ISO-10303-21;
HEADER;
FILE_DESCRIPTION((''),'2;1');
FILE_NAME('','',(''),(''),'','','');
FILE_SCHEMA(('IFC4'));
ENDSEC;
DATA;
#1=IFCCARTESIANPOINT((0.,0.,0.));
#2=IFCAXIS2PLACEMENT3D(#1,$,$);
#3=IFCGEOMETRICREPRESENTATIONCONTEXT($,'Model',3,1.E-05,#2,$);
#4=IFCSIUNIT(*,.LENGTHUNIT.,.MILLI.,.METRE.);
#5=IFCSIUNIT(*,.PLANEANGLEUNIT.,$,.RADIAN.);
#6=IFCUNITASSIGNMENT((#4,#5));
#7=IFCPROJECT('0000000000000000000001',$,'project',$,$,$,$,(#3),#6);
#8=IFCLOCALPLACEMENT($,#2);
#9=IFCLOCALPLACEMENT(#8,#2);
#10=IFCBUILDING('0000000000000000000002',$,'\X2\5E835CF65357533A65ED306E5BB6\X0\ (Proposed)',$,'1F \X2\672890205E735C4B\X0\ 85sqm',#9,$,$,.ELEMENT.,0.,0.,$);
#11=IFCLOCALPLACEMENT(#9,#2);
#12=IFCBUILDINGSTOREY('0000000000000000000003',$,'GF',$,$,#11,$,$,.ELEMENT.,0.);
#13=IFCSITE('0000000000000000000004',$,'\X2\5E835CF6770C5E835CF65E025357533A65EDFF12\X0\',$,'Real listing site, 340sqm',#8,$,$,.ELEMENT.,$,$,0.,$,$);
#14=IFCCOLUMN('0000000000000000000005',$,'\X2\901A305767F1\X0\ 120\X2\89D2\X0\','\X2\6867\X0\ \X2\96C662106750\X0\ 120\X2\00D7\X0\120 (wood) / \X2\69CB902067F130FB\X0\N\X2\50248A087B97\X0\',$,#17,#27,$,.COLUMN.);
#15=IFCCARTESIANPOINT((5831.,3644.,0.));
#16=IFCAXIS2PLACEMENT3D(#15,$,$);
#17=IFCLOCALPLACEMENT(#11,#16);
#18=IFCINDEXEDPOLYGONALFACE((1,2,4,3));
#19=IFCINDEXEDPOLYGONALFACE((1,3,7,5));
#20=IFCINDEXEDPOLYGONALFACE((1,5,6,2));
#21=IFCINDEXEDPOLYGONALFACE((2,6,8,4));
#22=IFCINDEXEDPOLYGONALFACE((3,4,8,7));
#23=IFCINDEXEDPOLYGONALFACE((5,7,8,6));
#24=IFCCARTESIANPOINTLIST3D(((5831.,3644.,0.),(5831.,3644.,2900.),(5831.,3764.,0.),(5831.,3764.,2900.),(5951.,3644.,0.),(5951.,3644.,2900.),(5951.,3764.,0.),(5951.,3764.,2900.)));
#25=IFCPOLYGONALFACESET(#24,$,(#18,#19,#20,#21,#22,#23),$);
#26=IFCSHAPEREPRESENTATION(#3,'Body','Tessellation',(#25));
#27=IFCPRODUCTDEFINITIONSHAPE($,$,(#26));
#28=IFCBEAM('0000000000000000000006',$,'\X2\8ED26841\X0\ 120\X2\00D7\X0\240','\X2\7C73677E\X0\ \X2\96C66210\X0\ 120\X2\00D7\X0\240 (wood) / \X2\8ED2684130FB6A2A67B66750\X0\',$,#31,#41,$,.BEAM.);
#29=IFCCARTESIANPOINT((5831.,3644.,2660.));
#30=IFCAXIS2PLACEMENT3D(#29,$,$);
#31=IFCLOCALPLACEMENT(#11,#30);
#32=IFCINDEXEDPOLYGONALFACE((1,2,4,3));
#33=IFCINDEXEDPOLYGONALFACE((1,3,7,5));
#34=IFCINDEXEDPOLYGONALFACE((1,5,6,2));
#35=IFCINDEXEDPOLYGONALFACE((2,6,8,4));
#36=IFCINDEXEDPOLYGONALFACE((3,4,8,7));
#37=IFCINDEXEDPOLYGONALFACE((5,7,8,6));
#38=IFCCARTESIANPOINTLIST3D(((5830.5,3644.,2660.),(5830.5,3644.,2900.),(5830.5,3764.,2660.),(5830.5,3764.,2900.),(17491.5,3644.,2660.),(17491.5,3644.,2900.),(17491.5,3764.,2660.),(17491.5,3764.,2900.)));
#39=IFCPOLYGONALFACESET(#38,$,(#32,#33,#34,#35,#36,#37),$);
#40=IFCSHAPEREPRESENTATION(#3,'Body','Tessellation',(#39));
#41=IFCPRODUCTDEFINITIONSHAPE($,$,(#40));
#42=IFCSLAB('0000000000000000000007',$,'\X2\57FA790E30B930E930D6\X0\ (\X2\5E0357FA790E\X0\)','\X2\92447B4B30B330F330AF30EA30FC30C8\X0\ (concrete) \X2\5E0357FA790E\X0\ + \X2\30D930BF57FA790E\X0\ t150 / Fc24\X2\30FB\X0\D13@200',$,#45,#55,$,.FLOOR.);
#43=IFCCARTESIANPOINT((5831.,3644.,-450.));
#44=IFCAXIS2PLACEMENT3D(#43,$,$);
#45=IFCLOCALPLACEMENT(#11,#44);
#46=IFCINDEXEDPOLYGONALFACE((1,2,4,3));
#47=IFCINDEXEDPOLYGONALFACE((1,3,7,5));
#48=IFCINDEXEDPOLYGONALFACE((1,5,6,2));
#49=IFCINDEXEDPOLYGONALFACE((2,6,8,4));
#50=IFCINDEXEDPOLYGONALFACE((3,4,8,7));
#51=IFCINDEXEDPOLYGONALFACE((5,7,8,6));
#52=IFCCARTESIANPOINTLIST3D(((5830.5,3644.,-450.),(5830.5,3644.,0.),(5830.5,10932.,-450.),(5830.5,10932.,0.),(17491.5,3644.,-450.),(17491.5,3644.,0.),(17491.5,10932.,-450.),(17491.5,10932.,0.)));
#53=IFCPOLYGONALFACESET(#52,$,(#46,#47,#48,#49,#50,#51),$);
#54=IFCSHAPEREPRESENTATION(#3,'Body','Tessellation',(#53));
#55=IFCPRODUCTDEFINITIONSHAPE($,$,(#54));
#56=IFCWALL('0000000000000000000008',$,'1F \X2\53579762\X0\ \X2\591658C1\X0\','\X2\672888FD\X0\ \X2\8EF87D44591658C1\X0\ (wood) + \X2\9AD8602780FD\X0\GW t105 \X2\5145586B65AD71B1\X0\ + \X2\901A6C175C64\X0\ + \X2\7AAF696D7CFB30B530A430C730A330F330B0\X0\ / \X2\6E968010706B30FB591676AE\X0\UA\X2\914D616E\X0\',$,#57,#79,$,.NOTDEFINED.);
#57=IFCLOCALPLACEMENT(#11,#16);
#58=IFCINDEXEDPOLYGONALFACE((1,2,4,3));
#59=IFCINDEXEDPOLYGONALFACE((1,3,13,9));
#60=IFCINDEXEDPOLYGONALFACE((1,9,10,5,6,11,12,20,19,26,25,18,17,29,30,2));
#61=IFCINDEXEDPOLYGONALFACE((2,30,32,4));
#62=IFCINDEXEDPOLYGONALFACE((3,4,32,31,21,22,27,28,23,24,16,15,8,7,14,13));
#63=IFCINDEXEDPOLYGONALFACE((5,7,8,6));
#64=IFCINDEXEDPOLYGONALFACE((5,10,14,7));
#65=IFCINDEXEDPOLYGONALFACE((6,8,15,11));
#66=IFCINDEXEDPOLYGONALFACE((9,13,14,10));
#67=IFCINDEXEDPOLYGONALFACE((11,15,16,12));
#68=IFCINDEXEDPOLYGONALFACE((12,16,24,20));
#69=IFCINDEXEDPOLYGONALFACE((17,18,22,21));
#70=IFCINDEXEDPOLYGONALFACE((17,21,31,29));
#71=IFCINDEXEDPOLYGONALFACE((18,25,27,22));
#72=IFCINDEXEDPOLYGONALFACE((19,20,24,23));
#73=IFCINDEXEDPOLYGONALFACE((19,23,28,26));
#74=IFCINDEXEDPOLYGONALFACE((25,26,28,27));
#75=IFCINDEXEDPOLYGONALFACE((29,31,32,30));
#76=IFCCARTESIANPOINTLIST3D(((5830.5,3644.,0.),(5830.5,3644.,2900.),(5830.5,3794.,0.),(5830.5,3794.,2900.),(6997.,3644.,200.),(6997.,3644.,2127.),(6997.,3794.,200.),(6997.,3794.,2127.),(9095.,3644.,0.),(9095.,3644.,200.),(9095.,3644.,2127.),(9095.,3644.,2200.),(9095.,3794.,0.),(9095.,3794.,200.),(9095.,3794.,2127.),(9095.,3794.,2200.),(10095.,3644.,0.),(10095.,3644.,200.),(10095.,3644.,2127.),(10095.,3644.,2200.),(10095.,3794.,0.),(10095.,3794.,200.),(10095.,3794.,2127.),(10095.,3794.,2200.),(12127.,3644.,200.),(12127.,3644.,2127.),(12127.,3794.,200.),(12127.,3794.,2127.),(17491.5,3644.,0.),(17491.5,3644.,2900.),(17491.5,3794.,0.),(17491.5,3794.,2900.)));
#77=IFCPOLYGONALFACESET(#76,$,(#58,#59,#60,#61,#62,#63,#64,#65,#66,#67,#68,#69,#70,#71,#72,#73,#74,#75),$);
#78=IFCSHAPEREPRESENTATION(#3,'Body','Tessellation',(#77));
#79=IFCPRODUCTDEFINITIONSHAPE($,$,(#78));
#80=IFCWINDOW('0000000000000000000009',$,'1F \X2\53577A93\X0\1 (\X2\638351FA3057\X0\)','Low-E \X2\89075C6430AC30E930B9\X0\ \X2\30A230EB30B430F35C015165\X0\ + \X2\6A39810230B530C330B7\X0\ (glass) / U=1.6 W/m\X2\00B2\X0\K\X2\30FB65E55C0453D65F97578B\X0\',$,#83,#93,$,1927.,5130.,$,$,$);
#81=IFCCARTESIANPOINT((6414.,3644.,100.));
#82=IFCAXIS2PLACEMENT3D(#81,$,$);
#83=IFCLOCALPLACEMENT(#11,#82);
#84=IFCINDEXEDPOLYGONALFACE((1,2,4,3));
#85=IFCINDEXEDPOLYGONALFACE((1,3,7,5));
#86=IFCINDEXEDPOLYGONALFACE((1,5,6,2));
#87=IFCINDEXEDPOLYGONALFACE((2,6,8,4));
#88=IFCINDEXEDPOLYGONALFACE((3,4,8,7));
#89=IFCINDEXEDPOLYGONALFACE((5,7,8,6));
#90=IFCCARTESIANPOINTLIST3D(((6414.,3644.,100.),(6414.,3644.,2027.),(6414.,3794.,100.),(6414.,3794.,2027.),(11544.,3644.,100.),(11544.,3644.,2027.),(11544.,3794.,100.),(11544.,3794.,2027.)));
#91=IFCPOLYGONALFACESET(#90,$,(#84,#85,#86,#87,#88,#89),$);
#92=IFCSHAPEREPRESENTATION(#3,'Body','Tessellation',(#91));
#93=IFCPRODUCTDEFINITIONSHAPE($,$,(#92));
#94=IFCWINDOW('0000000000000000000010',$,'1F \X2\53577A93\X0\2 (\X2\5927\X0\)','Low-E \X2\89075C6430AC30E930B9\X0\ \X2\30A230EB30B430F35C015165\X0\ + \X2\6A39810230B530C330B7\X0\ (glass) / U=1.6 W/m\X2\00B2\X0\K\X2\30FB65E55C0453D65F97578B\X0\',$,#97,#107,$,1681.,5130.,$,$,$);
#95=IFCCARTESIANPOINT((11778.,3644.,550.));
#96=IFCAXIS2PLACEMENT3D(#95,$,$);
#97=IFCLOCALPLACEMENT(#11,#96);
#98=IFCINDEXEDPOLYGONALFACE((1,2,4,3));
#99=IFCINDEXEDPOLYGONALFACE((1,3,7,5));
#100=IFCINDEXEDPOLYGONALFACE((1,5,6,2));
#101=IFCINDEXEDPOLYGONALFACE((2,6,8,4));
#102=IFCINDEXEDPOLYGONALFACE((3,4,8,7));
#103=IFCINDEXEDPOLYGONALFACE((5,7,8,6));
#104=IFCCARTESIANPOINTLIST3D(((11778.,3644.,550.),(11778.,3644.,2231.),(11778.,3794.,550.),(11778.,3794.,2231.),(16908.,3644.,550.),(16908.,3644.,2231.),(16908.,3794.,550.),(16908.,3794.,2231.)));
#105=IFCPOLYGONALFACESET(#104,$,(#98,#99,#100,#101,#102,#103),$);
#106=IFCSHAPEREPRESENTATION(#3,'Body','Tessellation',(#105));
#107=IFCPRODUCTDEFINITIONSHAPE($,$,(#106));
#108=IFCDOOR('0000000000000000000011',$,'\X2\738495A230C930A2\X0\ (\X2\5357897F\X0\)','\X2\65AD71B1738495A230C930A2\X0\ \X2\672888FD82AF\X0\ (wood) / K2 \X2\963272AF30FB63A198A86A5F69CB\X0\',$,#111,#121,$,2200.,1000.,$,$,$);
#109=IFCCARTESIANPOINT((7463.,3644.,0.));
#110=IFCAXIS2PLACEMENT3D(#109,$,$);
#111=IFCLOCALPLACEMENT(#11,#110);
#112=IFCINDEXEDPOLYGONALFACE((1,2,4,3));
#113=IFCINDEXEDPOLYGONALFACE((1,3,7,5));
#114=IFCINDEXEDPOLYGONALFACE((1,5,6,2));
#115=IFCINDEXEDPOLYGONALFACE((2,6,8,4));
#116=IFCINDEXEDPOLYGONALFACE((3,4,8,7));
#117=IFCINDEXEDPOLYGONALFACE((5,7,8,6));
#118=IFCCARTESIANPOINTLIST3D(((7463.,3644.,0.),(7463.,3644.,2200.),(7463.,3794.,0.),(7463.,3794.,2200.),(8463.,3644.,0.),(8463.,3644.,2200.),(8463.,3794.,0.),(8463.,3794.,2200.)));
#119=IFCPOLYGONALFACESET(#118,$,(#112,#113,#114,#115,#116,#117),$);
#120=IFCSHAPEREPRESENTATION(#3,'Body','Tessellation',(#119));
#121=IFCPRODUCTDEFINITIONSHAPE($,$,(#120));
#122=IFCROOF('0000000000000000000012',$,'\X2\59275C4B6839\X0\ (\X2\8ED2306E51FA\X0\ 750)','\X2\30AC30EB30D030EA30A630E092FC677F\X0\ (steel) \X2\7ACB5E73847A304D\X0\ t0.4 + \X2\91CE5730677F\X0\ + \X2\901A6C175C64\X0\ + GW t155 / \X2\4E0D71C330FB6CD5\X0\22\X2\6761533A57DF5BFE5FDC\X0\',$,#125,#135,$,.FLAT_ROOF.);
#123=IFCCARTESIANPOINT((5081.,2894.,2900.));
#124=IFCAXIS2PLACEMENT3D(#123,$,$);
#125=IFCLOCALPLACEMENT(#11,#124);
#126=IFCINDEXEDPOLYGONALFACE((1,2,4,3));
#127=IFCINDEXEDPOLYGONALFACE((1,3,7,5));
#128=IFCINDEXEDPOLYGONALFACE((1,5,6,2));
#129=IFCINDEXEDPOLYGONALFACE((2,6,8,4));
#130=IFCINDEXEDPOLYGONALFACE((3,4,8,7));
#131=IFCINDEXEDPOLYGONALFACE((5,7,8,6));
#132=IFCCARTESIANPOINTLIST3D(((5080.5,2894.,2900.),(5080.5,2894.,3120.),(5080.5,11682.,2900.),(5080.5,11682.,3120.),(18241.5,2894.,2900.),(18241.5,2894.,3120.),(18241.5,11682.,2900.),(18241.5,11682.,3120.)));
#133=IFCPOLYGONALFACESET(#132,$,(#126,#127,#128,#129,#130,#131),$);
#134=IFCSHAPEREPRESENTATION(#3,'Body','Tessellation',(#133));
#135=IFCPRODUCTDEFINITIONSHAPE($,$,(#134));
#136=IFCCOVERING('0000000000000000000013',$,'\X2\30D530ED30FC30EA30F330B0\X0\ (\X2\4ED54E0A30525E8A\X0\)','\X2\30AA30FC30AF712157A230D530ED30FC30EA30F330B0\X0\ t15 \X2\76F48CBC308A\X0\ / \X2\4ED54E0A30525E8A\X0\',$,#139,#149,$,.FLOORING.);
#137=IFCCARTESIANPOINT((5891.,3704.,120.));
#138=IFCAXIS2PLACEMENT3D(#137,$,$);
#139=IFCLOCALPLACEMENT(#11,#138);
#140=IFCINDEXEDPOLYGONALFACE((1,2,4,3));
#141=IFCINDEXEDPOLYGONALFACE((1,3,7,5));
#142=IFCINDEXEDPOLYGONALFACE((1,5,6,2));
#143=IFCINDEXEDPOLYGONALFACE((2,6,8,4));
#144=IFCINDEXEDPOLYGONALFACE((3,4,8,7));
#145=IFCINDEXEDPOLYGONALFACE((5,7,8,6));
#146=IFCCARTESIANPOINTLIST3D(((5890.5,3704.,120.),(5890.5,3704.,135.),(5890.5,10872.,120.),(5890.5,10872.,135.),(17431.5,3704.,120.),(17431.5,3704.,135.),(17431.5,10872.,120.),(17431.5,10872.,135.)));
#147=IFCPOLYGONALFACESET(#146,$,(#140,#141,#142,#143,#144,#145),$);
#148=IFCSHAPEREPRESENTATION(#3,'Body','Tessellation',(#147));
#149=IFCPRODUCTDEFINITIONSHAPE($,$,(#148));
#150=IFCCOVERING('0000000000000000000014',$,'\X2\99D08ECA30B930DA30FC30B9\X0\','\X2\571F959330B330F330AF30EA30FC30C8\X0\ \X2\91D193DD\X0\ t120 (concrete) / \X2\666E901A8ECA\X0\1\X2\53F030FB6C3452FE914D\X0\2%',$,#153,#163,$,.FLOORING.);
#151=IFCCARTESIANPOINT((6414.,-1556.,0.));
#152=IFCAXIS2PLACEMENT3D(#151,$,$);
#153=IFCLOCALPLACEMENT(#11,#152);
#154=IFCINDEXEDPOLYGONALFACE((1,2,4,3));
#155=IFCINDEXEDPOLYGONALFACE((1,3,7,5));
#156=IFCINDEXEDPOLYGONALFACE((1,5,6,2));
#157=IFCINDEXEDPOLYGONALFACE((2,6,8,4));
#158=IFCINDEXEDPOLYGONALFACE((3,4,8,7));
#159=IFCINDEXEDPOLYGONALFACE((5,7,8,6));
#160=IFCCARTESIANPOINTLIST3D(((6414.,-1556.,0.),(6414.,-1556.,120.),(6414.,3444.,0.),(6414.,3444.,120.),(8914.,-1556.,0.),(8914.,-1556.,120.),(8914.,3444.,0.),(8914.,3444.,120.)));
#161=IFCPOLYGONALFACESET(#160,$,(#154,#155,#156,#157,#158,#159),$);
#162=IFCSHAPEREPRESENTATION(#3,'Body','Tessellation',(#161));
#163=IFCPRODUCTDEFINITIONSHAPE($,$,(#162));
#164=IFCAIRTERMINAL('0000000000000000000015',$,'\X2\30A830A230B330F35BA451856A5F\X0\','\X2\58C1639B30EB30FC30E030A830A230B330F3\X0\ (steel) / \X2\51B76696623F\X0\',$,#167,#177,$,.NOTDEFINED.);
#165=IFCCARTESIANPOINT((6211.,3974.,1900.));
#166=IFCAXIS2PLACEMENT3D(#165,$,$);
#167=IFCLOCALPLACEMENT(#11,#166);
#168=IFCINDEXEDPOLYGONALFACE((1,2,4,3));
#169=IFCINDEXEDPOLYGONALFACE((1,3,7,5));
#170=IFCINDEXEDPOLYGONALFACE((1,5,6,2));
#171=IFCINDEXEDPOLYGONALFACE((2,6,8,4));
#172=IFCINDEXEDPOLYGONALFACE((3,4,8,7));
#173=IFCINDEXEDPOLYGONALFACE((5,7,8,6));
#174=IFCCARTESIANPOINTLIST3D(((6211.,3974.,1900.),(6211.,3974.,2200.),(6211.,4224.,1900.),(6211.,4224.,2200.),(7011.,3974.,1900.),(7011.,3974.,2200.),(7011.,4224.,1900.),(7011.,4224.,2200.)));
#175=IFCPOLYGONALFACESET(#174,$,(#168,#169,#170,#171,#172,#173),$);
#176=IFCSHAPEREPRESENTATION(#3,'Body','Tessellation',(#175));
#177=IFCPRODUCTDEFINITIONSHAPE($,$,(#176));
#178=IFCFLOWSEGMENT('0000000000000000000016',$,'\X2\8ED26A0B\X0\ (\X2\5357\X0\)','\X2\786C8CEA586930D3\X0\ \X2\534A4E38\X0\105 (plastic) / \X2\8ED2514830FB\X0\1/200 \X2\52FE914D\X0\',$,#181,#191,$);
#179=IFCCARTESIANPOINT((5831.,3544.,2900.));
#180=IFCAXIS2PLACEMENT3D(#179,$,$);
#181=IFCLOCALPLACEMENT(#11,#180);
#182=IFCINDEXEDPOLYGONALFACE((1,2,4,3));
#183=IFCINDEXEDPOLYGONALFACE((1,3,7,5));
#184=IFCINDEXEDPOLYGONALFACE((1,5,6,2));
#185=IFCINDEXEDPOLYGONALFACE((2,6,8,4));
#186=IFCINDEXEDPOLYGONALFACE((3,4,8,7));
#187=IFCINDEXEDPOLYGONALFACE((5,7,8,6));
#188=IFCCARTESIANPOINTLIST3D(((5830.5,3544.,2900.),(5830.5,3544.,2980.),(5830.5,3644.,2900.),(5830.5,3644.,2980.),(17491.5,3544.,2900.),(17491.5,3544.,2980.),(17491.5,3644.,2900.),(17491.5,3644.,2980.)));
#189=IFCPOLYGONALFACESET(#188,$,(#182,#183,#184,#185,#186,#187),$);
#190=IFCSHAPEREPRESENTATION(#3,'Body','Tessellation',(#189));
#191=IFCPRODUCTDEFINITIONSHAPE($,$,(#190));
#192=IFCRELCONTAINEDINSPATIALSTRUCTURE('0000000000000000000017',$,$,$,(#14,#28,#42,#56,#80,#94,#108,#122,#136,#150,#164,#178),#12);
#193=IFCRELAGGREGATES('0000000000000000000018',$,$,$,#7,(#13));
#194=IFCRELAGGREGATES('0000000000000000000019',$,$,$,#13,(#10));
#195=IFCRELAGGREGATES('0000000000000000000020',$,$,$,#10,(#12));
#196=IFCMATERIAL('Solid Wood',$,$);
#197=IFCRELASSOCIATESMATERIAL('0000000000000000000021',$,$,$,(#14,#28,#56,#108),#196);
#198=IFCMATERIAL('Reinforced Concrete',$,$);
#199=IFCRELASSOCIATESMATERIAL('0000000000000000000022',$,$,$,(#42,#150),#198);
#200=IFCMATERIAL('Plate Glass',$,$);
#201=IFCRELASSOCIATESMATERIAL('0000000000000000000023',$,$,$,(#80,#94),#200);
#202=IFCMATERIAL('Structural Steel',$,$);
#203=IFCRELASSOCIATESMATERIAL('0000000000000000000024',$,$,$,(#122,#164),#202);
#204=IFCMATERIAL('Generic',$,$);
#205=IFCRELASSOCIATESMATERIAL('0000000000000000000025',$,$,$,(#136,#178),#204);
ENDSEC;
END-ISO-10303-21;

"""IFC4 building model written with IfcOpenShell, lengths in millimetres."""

from ifc_helpers import new_model, si_unit, frame, frame_2d, origin, place, context, project, spatial, rectangle, extrude, material, element, fill, save


model = new_model("IFC4")

# Units and contexts
model_context = context("Model", 3, precision=1e-05, world=origin())
ifc_project = project(units=[si_unit("LENGTHUNIT", "METRE", prefix="MILLI"), si_unit("PLANEANGLEUNIT", "RADIAN")], contexts=[model_context])

# Site, building, storey
site_placement = place(None, origin())
site = spatial("IfcSite", under=ifc_project, at=site_placement, Name="広島県広島市南区旭２", ObjectType="Real listing site, 340sqm", CompositionType="ELEMENT", RefElevation=0.0)
building_placement = place(site_placement, origin())
building = spatial("IfcBuilding", under=site, at=building_placement, Name="広島南区旭の家 (Proposed)", ObjectType="1F 木造平屋 85sqm", CompositionType="ELEMENT", ElevationOfRefHeight=0.0, ElevationOfTerrain=0.0)
storey_placement = place(building_placement, origin())
storey = spatial("IfcBuildingStorey", under=building, at=storey_placement, Name="GF", CompositionType="ELEMENT", Elevation=0.0)

# Column
ifc_material_1 = material(Name="Solid Wood")
column_1_placement = place(storey_placement, frame((5831.0, 3644.0, 0.0)))
element("IfcColumn", 1, at=column_1_placement, inside=storey, material=ifc_material_1, Name="通し柱 120角", Description="桧 集成材 120×120 (wood) / 構造柱・N値計算", PredefinedType="COLUMN", context=model_context, shape_type="SweptSolid", body=[
    extrude(rectangle(XDim=120.0, YDim=120.0, at=frame_2d((60.0, 60.0))), frame((5831.0, 3644.0, 0.0)), (0.0, 0.0, 1.0), 2900.0),
])

# Beam
beam_1_placement = place(storey_placement, frame((5831.0, 3644.0, 2660.0)))
element("IfcBeam", 2, at=beam_1_placement, inside=storey, material=ifc_material_1, Name="軒桁 120×240", Description="米松 集成 120×240 (wood) / 軒桁・横架材", PredefinedType="BEAM", context=model_context, shape_type="SweptSolid", body=[
    extrude(rectangle(XDim=11661.0, YDim=120.0, at=frame_2d((5830.0, 60.0))), frame((5831.0, 3644.0, 2660.0)), (0.0, 0.0, 1.0), 240.0),
])

# Slab
ifc_material_2 = material(Name="Reinforced Concrete")
slab_1_placement = place(storey_placement, frame((5831.0, 3644.0, -450.0)))
element("IfcSlab", 3, at=slab_1_placement, inside=storey, material=ifc_material_2, Name="基礎スラブ (布基礎)", Description="鉄筋コンクリート (concrete) 布基礎 + ベタ基礎 t150 / Fc24・D13@200", PredefinedType="FLOOR", context=model_context, shape_type="SweptSolid", body=[
    extrude(rectangle(XDim=11661.0, YDim=7288.0, at=frame_2d((5830.0, 3644.0))), frame((5831.0, 3644.0, -450.0)), (0.0, 0.0, 1.0), 450.0),
])

# Wall, openings, windows, door
wall_1_placement = place(storey_placement, frame((5831.0, 3644.0, 0.0)))
wall_1 = element("IfcWall", 4, at=wall_1_placement, inside=storey, material=ifc_material_1, Name="1F 南面 外壁", Description="木製 軸組外壁 (wood) + 高性能GW t105 充填断熱 + 通気層 + 窯業系サイディング / 準耐火・外皮UA配慮", PredefinedType="NOTDEFINED", context=model_context, shape_type="SweptSolid", body=[
    extrude(rectangle(XDim=11661.0, YDim=150.0, at=frame_2d((5830.0, 75.0))), frame((5831.0, 3644.0, 0.0)), (0.0, 0.0, 1.0), 2900.0),
])
opening_1_placement = place(storey_placement, frame((6414.0, 3644.0, 100.0)))
opening_1 = element("IfcOpeningElement", 5, at=opening_1_placement, cuts=wall_1, PredefinedType="NOTDEFINED", context=model_context, shape_type="SweptSolid", body=[
    extrude(rectangle(XDim=5130.0, YDim=150.0, at=frame_2d((2565.0, 75.0))), frame((6414.0, 3644.0, 100.0)), (0.0, 0.0, 1.0), 1927.0),
])
opening_2_placement = place(storey_placement, frame((11778.0, 3644.0, 550.0)))
opening_2 = element("IfcOpeningElement", 6, at=opening_2_placement, cuts=wall_1, PredefinedType="NOTDEFINED", context=model_context, shape_type="SweptSolid", body=[
    extrude(rectangle(XDim=5130.0, YDim=150.0, at=frame_2d((2565.0, 75.0))), frame((11778.0, 3644.0, 550.0)), (0.0, 0.0, 1.0), 1681.0),
])
opening_3_placement = place(storey_placement, frame((7463.0, 3644.0, 0.0)))
opening_3 = element("IfcOpeningElement", 7, at=opening_3_placement, cuts=wall_1, PredefinedType="NOTDEFINED", context=model_context, shape_type="SweptSolid", body=[
    extrude(rectangle(XDim=1000.0, YDim=150.0, at=frame_2d((500.0, 75.0))), frame((7463.0, 3644.0, 0.0)), (0.0, 0.0, 1.0), 2200.0),
])
ifc_material_3 = material(Name="Plate Glass")
window_1_placement = place(storey_placement, frame((6414.0, 3644.0, 100.0)))
window_1 = element("IfcWindow", 8, at=window_1_placement, inside=storey, material=ifc_material_3, Name="1F 南窓1 (掃出し)", Description="Low-E 複層ガラス アルゴン封入 + 樹脂サッシ (glass) / U=1.6 W/m²K・日射取得型", OverallHeight=1927.0, OverallWidth=5130.0, context=model_context, shape_type="SweptSolid", body=[
    extrude(rectangle(XDim=5130.0, YDim=150.0, at=frame_2d((2565.0, 75.0))), frame((6414.0, 3644.0, 100.0)), (0.0, 0.0, 1.0), 1927.0),
])
fill(opening_1, window_1)
window_2_placement = place(storey_placement, frame((11778.0, 3644.0, 550.0)))
window_2 = element("IfcWindow", 9, at=window_2_placement, inside=storey, material=ifc_material_3, Name="1F 南窓2 (大)", Description="Low-E 複層ガラス アルゴン封入 + 樹脂サッシ (glass) / U=1.6 W/m²K・日射取得型", OverallHeight=1681.0, OverallWidth=5130.0, context=model_context, shape_type="SweptSolid", body=[
    extrude(rectangle(XDim=5130.0, YDim=150.0, at=frame_2d((2565.0, 75.0))), frame((11778.0, 3644.0, 550.0)), (0.0, 0.0, 1.0), 1681.0),
])
fill(opening_2, window_2)
door_placement = place(storey_placement, frame((7463.0, 3644.0, 0.0)))
door = element("IfcDoor", 10, at=door_placement, inside=storey, material=ifc_material_1, Name="玄関ドア (南西)", Description="断熱玄関ドア 木製芯 (wood) / K2 防犯・採風機構", OverallHeight=2200.0, OverallWidth=1000.0, context=model_context, shape_type="SweptSolid", body=[
    extrude(rectangle(XDim=1000.0, YDim=150.0, at=frame_2d((500.0, 75.0))), frame((7463.0, 3644.0, 0.0)), (0.0, 0.0, 1.0), 2200.0),
])
fill(opening_3, door)

# Roof
ifc_material_4 = material(Name="Structural Steel")
roof_placement = place(storey_placement, frame((5081.0, 2894.0, 2900.0)))
element("IfcRoof", 11, at=roof_placement, inside=storey, material=ifc_material_4, Name="大屋根 (軒の出 750)", Description="ガルバリウム鋼板 (steel) 立平葺き t0.4 + 野地板 + 通気層 + GW t155 / 不燃・法22条区域対応", PredefinedType="FLAT_ROOF", context=model_context, shape_type="SweptSolid", body=[
    extrude(rectangle(XDim=13161.0, YDim=8788.0, at=frame_2d((6580.0, 4394.0))), frame((5081.0, 2894.0, 2900.0)), (0.0, 0.0, 1.0), 220.0),
])

# Coverings
ifc_material_5 = material(Name="Generic")
covering_1_placement = place(storey_placement, frame((5891.0, 3704.0, 120.0)))
element("IfcCovering", 12, at=covering_1_placement, inside=storey, material=ifc_material_5, Name="フローリング (仕上げ床)", Description="オーク無垢フローリング t15 直貼り / 仕上げ床", PredefinedType="FLOORING", context=model_context, shape_type="SweptSolid", body=[
    extrude(rectangle(XDim=11541.0, YDim=7168.0, at=frame_2d((5770.0, 3584.0))), frame((5891.0, 3704.0, 120.0)), (0.0, 0.0, 1.0), 15.0),
])
covering_2_placement = place(storey_placement, frame((6414.0, -1556.0, 0.0)))
element("IfcCovering", 13, at=covering_2_placement, inside=storey, material=ifc_material_2, Name="駐車スペース", Description="土間コンクリート 金鏝 t120 (concrete) / 普通車1台・水勾配2%", PredefinedType="FLOORING", context=model_context, shape_type="SweptSolid", body=[
    extrude(rectangle(XDim=2500.0, YDim=5000.0, at=frame_2d((1250.0, 2500.0))), frame((6414.0, -1556.0, 0.0)), (0.0, 0.0, 1.0), 120.0),
])

# Air terminal
air_terminal_placement = place(storey_placement, frame((6211.0, 3974.0, 1900.0)))
element("IfcAirTerminal", 14, at=air_terminal_placement, inside=storey, material=ifc_material_4, Name="エアコン室内機", Description="壁掛ルームエアコン (steel) / 冷暖房", PredefinedType="NOTDEFINED", context=model_context, shape_type="SweptSolid", body=[
    extrude(rectangle(XDim=800.0, YDim=250.0, at=frame_2d((400.0, 125.0))), frame((6211.0, 3974.0, 1900.0)), (0.0, 0.0, 1.0), 300.0),
])

# Flow segment
flow_segment_1_placement = place(storey_placement, frame((5831.0, 3544.0, 2900.0)))
element("IfcFlowSegment", 15, at=flow_segment_1_placement, inside=storey, material=ifc_material_5, Name="軒樋 (南)", Description="硬質塩ビ 半丸105 (plastic) / 軒先・1/200 勾配", context=model_context, shape_type="SweptSolid", body=[
    extrude(rectangle(XDim=11661.0, YDim=100.0, at=frame_2d((5830.0, 50.0))), frame((5831.0, 3544.0, 2900.0)), (0.0, 0.0, 1.0), 80.0),
])

save(model, "model.ifc")
